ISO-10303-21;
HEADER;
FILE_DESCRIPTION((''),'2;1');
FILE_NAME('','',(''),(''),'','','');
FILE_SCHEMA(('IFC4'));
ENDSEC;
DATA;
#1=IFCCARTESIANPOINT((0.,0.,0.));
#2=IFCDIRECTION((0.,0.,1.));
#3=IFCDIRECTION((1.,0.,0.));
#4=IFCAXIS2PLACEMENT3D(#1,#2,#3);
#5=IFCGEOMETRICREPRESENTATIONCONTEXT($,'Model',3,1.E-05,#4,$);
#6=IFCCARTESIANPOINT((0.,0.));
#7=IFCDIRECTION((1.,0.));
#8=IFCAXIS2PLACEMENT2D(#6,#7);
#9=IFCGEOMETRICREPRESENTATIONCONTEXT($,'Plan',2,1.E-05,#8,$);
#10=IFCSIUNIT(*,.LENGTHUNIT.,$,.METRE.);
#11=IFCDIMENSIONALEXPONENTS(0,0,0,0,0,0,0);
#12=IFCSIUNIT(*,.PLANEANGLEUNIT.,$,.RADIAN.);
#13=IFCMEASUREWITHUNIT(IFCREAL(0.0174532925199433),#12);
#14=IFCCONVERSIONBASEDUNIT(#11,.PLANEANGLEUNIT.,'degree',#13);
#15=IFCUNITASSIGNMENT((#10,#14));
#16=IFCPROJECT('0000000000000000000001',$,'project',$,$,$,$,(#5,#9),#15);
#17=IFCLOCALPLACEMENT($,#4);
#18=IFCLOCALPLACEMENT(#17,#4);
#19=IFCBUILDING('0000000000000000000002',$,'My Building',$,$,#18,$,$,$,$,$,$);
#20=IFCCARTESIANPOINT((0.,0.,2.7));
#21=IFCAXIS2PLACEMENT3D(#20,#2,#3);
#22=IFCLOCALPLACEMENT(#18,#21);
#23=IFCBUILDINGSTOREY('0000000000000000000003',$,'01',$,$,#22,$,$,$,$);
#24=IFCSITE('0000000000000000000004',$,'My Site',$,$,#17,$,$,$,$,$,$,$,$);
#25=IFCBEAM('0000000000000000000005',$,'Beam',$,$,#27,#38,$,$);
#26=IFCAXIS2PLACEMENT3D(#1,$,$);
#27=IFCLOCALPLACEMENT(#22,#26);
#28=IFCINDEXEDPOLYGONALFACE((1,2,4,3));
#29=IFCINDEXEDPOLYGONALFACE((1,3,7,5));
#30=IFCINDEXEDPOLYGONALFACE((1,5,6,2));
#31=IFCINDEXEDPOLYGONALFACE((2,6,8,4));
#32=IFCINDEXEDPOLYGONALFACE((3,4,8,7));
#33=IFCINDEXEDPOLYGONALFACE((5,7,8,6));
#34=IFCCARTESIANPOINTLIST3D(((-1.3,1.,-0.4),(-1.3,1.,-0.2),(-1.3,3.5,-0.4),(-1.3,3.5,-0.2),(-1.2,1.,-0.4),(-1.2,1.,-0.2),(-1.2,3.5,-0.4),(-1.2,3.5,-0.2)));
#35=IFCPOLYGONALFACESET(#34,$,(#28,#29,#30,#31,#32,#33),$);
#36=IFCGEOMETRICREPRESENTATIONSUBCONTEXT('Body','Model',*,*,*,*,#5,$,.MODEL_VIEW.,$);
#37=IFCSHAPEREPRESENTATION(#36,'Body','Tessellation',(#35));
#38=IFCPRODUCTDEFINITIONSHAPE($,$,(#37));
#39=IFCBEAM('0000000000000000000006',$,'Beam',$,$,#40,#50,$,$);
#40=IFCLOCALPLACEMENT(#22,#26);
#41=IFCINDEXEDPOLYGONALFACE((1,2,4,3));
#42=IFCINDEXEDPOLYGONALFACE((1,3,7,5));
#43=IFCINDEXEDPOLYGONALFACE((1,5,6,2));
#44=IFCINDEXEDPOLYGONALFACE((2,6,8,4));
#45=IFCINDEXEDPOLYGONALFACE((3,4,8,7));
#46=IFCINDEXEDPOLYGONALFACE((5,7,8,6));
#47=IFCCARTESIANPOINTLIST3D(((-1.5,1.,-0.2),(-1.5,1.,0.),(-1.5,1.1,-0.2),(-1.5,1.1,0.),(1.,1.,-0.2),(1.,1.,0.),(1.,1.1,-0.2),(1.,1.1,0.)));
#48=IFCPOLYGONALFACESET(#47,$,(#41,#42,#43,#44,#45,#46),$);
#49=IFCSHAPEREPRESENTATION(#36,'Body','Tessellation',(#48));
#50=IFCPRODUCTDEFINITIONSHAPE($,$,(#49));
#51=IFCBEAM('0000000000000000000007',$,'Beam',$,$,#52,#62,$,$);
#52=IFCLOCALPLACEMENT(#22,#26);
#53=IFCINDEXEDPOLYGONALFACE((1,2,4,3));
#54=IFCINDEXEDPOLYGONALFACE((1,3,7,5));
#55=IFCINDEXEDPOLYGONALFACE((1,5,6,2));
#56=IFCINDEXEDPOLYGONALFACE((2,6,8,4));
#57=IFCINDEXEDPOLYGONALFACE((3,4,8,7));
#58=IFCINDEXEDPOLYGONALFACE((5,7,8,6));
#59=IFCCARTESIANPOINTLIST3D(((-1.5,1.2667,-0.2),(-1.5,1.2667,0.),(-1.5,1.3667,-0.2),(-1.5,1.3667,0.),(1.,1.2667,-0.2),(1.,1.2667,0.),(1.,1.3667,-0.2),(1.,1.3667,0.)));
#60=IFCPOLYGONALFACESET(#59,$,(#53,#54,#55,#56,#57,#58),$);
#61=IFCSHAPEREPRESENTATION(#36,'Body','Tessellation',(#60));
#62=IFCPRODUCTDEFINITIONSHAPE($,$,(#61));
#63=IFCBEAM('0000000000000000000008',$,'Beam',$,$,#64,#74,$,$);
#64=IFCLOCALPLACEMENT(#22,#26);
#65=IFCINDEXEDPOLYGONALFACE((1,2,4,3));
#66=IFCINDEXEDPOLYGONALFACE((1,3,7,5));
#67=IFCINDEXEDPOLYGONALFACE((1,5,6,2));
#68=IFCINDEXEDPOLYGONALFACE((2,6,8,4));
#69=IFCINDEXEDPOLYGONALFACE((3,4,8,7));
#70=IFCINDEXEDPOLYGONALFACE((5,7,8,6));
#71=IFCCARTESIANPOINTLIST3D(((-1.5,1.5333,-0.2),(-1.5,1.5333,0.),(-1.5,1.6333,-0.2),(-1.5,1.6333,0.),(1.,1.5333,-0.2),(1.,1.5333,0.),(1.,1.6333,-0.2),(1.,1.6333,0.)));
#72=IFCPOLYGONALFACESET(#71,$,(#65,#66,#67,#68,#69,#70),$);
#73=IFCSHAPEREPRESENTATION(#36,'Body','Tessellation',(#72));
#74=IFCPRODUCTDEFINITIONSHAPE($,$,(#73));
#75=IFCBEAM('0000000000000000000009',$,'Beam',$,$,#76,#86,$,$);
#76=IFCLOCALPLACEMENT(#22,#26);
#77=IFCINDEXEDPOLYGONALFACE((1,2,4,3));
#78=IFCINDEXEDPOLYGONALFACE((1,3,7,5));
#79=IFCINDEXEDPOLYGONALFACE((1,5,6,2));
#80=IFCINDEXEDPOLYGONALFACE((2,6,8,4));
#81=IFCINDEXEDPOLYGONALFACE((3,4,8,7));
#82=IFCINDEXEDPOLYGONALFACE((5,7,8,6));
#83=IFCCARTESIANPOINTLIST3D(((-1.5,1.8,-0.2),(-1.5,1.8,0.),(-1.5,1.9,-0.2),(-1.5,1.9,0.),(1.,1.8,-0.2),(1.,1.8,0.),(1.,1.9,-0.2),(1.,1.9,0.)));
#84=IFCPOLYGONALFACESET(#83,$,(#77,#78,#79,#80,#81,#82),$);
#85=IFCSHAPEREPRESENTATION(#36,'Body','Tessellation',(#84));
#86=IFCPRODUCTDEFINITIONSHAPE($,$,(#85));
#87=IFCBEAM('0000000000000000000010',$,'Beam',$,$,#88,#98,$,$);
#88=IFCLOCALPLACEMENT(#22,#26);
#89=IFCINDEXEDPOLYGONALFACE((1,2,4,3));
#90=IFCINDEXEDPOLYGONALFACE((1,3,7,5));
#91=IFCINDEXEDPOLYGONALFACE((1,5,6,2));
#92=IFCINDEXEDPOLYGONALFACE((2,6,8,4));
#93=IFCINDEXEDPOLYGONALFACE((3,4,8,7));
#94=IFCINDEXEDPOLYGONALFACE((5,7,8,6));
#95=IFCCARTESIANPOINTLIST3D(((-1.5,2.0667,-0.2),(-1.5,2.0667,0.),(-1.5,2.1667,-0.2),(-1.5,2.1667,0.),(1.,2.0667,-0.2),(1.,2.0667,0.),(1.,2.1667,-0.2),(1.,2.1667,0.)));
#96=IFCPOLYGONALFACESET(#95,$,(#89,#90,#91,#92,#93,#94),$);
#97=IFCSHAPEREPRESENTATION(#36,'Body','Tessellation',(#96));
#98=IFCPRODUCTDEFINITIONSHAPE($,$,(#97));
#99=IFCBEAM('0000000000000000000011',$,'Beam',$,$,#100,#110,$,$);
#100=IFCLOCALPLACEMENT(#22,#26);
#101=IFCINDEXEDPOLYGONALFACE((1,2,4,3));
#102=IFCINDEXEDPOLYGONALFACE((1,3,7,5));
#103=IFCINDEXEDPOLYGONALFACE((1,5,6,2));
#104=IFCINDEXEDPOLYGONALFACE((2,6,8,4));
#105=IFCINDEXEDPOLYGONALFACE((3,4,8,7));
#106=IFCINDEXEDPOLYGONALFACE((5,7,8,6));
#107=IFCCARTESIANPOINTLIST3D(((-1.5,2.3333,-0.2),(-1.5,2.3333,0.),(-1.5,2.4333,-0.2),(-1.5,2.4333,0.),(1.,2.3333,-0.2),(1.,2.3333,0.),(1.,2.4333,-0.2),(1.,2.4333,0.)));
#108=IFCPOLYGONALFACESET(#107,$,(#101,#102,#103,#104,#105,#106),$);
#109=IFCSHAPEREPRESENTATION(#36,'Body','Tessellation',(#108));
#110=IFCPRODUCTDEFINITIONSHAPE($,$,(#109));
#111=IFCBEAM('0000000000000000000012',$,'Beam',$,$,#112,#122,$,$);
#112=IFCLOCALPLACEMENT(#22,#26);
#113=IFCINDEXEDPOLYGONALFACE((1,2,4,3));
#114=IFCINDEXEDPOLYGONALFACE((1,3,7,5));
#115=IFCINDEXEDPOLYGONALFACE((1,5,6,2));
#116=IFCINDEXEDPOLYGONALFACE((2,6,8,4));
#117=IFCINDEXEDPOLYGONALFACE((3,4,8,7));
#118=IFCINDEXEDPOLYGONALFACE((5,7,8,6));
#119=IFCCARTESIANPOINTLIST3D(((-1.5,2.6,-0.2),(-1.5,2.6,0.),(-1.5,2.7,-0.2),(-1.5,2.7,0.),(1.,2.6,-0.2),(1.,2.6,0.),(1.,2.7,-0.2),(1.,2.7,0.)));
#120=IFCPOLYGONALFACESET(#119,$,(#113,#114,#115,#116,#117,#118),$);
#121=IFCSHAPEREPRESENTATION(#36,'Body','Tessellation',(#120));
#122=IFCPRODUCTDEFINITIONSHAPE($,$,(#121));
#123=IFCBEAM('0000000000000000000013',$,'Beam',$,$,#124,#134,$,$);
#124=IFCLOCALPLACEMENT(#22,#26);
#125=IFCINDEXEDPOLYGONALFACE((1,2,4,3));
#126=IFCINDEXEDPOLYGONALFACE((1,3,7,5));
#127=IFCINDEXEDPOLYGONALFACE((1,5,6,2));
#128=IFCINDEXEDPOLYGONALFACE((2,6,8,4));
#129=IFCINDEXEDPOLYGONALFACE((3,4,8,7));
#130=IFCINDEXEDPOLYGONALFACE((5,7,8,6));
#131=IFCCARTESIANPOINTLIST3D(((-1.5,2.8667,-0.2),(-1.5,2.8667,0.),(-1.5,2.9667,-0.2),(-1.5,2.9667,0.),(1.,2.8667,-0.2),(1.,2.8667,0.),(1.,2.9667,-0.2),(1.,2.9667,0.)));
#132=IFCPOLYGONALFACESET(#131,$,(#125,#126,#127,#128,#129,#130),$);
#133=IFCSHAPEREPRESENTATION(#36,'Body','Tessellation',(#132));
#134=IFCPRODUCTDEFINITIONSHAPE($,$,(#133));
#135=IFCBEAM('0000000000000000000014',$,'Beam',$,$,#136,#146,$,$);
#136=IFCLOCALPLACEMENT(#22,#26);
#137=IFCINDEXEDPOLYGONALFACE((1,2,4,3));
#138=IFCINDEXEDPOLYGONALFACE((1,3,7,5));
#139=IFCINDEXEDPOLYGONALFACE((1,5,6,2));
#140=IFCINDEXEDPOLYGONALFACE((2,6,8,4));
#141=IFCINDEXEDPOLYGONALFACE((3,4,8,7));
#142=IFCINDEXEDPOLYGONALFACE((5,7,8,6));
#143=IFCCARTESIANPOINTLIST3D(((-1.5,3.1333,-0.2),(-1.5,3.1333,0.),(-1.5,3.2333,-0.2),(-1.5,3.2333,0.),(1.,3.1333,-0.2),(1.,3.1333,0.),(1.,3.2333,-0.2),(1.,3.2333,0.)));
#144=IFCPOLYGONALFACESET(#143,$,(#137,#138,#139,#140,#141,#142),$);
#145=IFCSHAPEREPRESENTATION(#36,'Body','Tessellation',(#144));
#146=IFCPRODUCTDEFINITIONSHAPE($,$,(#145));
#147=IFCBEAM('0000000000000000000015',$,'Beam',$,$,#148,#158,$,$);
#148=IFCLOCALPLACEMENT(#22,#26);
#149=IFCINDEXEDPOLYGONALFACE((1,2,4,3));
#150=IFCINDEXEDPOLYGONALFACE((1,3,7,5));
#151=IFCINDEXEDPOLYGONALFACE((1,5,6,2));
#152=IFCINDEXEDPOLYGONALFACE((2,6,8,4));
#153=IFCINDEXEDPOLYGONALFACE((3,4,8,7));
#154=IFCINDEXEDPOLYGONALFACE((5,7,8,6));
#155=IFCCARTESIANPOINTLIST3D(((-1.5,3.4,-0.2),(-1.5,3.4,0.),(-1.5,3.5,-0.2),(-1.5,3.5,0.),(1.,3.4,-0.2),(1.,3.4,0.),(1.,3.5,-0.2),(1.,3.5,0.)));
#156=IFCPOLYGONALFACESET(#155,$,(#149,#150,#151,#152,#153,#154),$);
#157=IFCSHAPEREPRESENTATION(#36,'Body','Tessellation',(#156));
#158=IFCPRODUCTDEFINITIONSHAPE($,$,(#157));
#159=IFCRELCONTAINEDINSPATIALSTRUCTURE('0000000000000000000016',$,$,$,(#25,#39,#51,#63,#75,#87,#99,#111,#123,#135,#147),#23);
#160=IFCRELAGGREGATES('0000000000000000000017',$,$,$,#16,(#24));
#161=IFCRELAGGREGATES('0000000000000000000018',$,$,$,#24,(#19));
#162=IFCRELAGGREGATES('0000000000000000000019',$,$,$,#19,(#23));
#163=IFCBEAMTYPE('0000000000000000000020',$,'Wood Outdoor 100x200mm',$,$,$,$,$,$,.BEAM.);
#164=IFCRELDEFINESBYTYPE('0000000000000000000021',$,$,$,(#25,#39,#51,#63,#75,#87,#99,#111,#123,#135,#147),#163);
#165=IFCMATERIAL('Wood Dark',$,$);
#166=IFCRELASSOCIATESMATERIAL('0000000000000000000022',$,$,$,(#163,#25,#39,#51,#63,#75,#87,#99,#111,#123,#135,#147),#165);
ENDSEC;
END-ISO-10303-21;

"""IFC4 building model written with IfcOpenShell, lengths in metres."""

from ifc_helpers import new_model, entity, si_unit, converted_unit, frame, origin_with_axes, origin_2d_with_axis, place, context, subcontext, project, spatial, rectangle, extrude, material, material_profile, profile_set, profile_usage, type_object, element, save


model = new_model("IFC4")

# Units and contexts
model_context = context("Model", 3, precision=1e-05, world=origin_with_axes())
plan_context = context("Plan", 2, precision=1e-05, world=origin_2d_with_axis())
body_context_1 = subcontext(model_context, "Body", "Model", "MODEL_VIEW")
ifc_project = project(units=[si_unit("LENGTHUNIT", "METRE"), converted_unit("PLANEANGLEUNIT", "degree", entity("IfcReal", 0.0174532925199433), si_unit("PLANEANGLEUNIT", "RADIAN"), dimensions=[0, 0, 0, 0, 0, 0, 0])], contexts=[model_context, plan_context])

# Site, building, storey
site_placement = place(None, origin_with_axes())
site = spatial("IfcSite", under=ifc_project, at=site_placement, Name="My Site")
building_placement = place(site_placement, origin_with_axes())
building = spatial("IfcBuilding", under=site, at=building_placement, Name="My Building")
storey_placement = place(building_placement, frame((0.0, 0.0, 2.7), z_axis=(0.0, 0.0, 1.0), x_axis=(1.0, 0.0, 0.0)))
storey = spatial("IfcBuildingStorey", under=building, at=storey_placement, Name="01")

# Beams
ifc_material_1 = material(Name="Wood Dark")
ifc_material_profile = material_profile(ifc_material_1, rectangle(XDim=0.1, YDim=0.2, kind="CURVE"))
ifc_profile_set = profile_set([ifc_material_profile])
ifc_profile_usage_1 = profile_usage(ifc_profile_set, cardinal=8)
beam_type = type_object("IfcBeamType", Name="Wood Outdoor 100x200mm", PredefinedType="BEAM", material=ifc_profile_set)
beam_1_placement = place(storey_placement, frame((-1.25, 1.0, -0.2), z_axis=(0.0, 1.0, 0.0), x_axis=(-1.0, 0.0, 0.0)))
element("IfcBeam", 1, at=beam_1_placement, inside=storey, type_object=beam_type, material=ifc_profile_usage_1, Name="Beam", context=body_context_1, shape_type="SweptSolid", body=[
    extrude(rectangle(XDim=0.1, YDim=0.2, kind="CURVE"), frame((0.0, -0.1, 0.0), z_axis=(0.0, 0.0, 1.0), x_axis=(1.0, 0.0, 0.0)), (0.0, 0.0, 1.0), 2.5),
])
ifc_profile_usage_2 = profile_usage(ifc_profile_set, cardinal=8)
beam_2_placement = place(storey_placement, frame((-1.5, 1.05, 0.0), z_axis=(1.0, 0.0, 0.0), x_axis=(0.0, 1.0, 0.0)))
element("IfcBeam", 2, at=beam_2_placement, inside=storey, type_object=beam_type, material=ifc_profile_usage_2, Name="Beam", context=body_context_1, shape_type="SweptSolid", body=[
    extrude(rectangle(XDim=0.1, YDim=0.2, kind="CURVE"), frame((0.0, -0.1, 0.0), z_axis=(0.0, 0.0, 1.0), x_axis=(1.0, 0.0, 0.0)), (0.0, 0.0, 1.0), 2.5),
])
ifc_profile_usage_3 = profile_usage(ifc_profile_set, cardinal=8)
beam_3_placement = place(storey_placement, frame((-1.5, 1.3167, 0.0), z_axis=(1.0, 0.0, 0.0), x_axis=(0.0, 1.0, 0.0)))
element("IfcBeam", 3, at=beam_3_placement, inside=storey, type_object=beam_type, material=ifc_profile_usage_3, Name="Beam", context=body_context_1, shape_type="SweptSolid", body=[
    extrude(rectangle(XDim=0.1, YDim=0.2, kind="CURVE"), frame((0.0, -0.1, 0.0), z_axis=(0.0, 0.0, 1.0), x_axis=(1.0, 0.0, 0.0)), (0.0, 0.0, 1.0), 2.5),
])
ifc_profile_usage_4 = profile_usage(ifc_profile_set, cardinal=8)
beam_4_placement = place(storey_placement, frame((-1.5, 1.5833, 0.0), z_axis=(1.0, 0.0, 0.0), x_axis=(0.0, 1.0, 0.0)))
element("IfcBeam", 4, at=beam_4_placement, inside=storey, type_object=beam_type, material=ifc_profile_usage_4, Name="Beam", context=body_context_1, shape_type="SweptSolid", body=[
    extrude(rectangle(XDim=0.1, YDim=0.2, kind="CURVE"), frame((0.0, -0.1, 0.0), z_axis=(0.0, 0.0, 1.0), x_axis=(1.0, 0.0, 0.0)), (0.0, 0.0, 1.0), 2.5),
])
ifc_profile_usage_5 = profile_usage(ifc_profile_set, cardinal=8)
beam_5_placement = place(storey_placement, frame((-1.5, 1.85, 0.0), z_axis=(1.0, 0.0, 0.0), x_axis=(0.0, 1.0, 0.0)))
element("IfcBeam", 5, at=beam_5_placement, inside=storey, type_object=beam_type, material=ifc_profile_usage_5, Name="Beam", context=body_context_1, shape_type="SweptSolid", body=[
    extrude(rectangle(XDim=0.1, YDim=0.2, kind="CURVE"), frame((0.0, -0.1, 0.0), z_axis=(0.0, 0.0, 1.0), x_axis=(1.0, 0.0, 0.0)), (0.0, 0.0, 1.0), 2.5),
])
ifc_profile_usage_6 = profile_usage(ifc_profile_set, cardinal=8)
beam_6_placement = place(storey_placement, frame((-1.5, 2.1167, 0.0), z_axis=(1.0, 0.0, 0.0), x_axis=(0.0, 1.0, 0.0)))
element("IfcBeam", 6, at=beam_6_placement, inside=storey, type_object=beam_type, material=ifc_profile_usage_6, Name="Beam", context=body_context_1, shape_type="SweptSolid", body=[
    extrude(rectangle(XDim=0.1, YDim=0.2, kind="CURVE"), frame((0.0, -0.1, 0.0), z_axis=(0.0, 0.0, 1.0), x_axis=(1.0, 0.0, 0.0)), (0.0, 0.0, 1.0), 2.5),
])
ifc_profile_usage_7 = profile_usage(ifc_profile_set, cardinal=8)
beam_7_placement = place(storey_placement, frame((-1.5, 2.3833, 0.0), z_axis=(1.0, 0.0, 0.0), x_axis=(0.0, 1.0, 0.0)))
element("IfcBeam", 7, at=beam_7_placement, inside=storey, type_object=beam_type, material=ifc_profile_usage_7, Name="Beam", context=body_context_1, shape_type="SweptSolid", body=[
    extrude(rectangle(XDim=0.1, YDim=0.2, kind="CURVE"), frame((0.0, -0.1, 0.0), z_axis=(0.0, 0.0, 1.0), x_axis=(1.0, 0.0, 0.0)), (0.0, 0.0, 1.0), 2.5),
])
ifc_profile_usage_8 = profile_usage(ifc_profile_set, cardinal=8)
beam_8_placement = place(storey_placement, frame((-1.5, 2.65, 0.0), z_axis=(1.0, 0.0, 0.0), x_axis=(0.0, 1.0, 0.0)))
element("IfcBeam", 8, at=beam_8_placement, inside=storey, type_object=beam_type, material=ifc_profile_usage_8, Name="Beam", context=body_context_1, shape_type="SweptSolid", body=[
    extrude(rectangle(XDim=0.1, YDim=0.2, kind="CURVE"), frame((0.0, -0.1, 0.0), z_axis=(0.0, 0.0, 1.0), x_axis=(1.0, 0.0, 0.0)), (0.0, 0.0, 1.0), 2.5),
])
ifc_profile_usage_9 = profile_usage(ifc_profile_set, cardinal=8)
beam_9_placement = place(storey_placement, frame((-1.5, 2.9167, 0.0), z_axis=(1.0, 0.0, 0.0), x_axis=(0.0, 1.0, 0.0)))
element("IfcBeam", 9, at=beam_9_placement, inside=storey, type_object=beam_type, material=ifc_profile_usage_9, Name="Beam", context=body_context_1, shape_type="SweptSolid", body=[
    extrude(rectangle(XDim=0.1, YDim=0.2, kind="CURVE"), frame((0.0, -0.1, 0.0), z_axis=(0.0, 0.0, 1.0), x_axis=(1.0, 0.0, 0.0)), (0.0, 0.0, 1.0), 2.5),
])
ifc_profile_usage_10 = profile_usage(ifc_profile_set, cardinal=8)
beam_10_placement = place(storey_placement, frame((-1.5, 3.1833, 0.0), z_axis=(1.0, 0.0, 0.0), x_axis=(0.0, 1.0, 0.0)))
element("IfcBeam", 10, at=beam_10_placement, inside=storey, type_object=beam_type, material=ifc_profile_usage_10, Name="Beam", context=body_context_1, shape_type="SweptSolid", body=[
    extrude(rectangle(XDim=0.1, YDim=0.2, kind="CURVE"), frame((0.0, -0.1, 0.0), z_axis=(0.0, 0.0, 1.0), x_axis=(1.0, 0.0, 0.0)), (0.0, 0.0, 1.0), 2.5),
])
ifc_profile_usage_11 = profile_usage(ifc_profile_set, cardinal=8)
beam_11_placement = place(storey_placement, frame((-1.5, 3.45, 0.0), z_axis=(1.0, 0.0, 0.0), x_axis=(0.0, 1.0, 0.0)))
element("IfcBeam", 11, at=beam_11_placement, inside=storey, type_object=beam_type, material=ifc_profile_usage_11, Name="Beam", context=body_context_1, shape_type="SweptSolid", body=[
    extrude(rectangle(XDim=0.1, YDim=0.2, kind="CURVE"), frame((0.0, -0.1, 0.0), z_axis=(0.0, 0.0, 1.0), x_axis=(1.0, 0.0, 0.0)), (0.0, 0.0, 1.0), 2.5),
])

save(model, "model.ifc")
